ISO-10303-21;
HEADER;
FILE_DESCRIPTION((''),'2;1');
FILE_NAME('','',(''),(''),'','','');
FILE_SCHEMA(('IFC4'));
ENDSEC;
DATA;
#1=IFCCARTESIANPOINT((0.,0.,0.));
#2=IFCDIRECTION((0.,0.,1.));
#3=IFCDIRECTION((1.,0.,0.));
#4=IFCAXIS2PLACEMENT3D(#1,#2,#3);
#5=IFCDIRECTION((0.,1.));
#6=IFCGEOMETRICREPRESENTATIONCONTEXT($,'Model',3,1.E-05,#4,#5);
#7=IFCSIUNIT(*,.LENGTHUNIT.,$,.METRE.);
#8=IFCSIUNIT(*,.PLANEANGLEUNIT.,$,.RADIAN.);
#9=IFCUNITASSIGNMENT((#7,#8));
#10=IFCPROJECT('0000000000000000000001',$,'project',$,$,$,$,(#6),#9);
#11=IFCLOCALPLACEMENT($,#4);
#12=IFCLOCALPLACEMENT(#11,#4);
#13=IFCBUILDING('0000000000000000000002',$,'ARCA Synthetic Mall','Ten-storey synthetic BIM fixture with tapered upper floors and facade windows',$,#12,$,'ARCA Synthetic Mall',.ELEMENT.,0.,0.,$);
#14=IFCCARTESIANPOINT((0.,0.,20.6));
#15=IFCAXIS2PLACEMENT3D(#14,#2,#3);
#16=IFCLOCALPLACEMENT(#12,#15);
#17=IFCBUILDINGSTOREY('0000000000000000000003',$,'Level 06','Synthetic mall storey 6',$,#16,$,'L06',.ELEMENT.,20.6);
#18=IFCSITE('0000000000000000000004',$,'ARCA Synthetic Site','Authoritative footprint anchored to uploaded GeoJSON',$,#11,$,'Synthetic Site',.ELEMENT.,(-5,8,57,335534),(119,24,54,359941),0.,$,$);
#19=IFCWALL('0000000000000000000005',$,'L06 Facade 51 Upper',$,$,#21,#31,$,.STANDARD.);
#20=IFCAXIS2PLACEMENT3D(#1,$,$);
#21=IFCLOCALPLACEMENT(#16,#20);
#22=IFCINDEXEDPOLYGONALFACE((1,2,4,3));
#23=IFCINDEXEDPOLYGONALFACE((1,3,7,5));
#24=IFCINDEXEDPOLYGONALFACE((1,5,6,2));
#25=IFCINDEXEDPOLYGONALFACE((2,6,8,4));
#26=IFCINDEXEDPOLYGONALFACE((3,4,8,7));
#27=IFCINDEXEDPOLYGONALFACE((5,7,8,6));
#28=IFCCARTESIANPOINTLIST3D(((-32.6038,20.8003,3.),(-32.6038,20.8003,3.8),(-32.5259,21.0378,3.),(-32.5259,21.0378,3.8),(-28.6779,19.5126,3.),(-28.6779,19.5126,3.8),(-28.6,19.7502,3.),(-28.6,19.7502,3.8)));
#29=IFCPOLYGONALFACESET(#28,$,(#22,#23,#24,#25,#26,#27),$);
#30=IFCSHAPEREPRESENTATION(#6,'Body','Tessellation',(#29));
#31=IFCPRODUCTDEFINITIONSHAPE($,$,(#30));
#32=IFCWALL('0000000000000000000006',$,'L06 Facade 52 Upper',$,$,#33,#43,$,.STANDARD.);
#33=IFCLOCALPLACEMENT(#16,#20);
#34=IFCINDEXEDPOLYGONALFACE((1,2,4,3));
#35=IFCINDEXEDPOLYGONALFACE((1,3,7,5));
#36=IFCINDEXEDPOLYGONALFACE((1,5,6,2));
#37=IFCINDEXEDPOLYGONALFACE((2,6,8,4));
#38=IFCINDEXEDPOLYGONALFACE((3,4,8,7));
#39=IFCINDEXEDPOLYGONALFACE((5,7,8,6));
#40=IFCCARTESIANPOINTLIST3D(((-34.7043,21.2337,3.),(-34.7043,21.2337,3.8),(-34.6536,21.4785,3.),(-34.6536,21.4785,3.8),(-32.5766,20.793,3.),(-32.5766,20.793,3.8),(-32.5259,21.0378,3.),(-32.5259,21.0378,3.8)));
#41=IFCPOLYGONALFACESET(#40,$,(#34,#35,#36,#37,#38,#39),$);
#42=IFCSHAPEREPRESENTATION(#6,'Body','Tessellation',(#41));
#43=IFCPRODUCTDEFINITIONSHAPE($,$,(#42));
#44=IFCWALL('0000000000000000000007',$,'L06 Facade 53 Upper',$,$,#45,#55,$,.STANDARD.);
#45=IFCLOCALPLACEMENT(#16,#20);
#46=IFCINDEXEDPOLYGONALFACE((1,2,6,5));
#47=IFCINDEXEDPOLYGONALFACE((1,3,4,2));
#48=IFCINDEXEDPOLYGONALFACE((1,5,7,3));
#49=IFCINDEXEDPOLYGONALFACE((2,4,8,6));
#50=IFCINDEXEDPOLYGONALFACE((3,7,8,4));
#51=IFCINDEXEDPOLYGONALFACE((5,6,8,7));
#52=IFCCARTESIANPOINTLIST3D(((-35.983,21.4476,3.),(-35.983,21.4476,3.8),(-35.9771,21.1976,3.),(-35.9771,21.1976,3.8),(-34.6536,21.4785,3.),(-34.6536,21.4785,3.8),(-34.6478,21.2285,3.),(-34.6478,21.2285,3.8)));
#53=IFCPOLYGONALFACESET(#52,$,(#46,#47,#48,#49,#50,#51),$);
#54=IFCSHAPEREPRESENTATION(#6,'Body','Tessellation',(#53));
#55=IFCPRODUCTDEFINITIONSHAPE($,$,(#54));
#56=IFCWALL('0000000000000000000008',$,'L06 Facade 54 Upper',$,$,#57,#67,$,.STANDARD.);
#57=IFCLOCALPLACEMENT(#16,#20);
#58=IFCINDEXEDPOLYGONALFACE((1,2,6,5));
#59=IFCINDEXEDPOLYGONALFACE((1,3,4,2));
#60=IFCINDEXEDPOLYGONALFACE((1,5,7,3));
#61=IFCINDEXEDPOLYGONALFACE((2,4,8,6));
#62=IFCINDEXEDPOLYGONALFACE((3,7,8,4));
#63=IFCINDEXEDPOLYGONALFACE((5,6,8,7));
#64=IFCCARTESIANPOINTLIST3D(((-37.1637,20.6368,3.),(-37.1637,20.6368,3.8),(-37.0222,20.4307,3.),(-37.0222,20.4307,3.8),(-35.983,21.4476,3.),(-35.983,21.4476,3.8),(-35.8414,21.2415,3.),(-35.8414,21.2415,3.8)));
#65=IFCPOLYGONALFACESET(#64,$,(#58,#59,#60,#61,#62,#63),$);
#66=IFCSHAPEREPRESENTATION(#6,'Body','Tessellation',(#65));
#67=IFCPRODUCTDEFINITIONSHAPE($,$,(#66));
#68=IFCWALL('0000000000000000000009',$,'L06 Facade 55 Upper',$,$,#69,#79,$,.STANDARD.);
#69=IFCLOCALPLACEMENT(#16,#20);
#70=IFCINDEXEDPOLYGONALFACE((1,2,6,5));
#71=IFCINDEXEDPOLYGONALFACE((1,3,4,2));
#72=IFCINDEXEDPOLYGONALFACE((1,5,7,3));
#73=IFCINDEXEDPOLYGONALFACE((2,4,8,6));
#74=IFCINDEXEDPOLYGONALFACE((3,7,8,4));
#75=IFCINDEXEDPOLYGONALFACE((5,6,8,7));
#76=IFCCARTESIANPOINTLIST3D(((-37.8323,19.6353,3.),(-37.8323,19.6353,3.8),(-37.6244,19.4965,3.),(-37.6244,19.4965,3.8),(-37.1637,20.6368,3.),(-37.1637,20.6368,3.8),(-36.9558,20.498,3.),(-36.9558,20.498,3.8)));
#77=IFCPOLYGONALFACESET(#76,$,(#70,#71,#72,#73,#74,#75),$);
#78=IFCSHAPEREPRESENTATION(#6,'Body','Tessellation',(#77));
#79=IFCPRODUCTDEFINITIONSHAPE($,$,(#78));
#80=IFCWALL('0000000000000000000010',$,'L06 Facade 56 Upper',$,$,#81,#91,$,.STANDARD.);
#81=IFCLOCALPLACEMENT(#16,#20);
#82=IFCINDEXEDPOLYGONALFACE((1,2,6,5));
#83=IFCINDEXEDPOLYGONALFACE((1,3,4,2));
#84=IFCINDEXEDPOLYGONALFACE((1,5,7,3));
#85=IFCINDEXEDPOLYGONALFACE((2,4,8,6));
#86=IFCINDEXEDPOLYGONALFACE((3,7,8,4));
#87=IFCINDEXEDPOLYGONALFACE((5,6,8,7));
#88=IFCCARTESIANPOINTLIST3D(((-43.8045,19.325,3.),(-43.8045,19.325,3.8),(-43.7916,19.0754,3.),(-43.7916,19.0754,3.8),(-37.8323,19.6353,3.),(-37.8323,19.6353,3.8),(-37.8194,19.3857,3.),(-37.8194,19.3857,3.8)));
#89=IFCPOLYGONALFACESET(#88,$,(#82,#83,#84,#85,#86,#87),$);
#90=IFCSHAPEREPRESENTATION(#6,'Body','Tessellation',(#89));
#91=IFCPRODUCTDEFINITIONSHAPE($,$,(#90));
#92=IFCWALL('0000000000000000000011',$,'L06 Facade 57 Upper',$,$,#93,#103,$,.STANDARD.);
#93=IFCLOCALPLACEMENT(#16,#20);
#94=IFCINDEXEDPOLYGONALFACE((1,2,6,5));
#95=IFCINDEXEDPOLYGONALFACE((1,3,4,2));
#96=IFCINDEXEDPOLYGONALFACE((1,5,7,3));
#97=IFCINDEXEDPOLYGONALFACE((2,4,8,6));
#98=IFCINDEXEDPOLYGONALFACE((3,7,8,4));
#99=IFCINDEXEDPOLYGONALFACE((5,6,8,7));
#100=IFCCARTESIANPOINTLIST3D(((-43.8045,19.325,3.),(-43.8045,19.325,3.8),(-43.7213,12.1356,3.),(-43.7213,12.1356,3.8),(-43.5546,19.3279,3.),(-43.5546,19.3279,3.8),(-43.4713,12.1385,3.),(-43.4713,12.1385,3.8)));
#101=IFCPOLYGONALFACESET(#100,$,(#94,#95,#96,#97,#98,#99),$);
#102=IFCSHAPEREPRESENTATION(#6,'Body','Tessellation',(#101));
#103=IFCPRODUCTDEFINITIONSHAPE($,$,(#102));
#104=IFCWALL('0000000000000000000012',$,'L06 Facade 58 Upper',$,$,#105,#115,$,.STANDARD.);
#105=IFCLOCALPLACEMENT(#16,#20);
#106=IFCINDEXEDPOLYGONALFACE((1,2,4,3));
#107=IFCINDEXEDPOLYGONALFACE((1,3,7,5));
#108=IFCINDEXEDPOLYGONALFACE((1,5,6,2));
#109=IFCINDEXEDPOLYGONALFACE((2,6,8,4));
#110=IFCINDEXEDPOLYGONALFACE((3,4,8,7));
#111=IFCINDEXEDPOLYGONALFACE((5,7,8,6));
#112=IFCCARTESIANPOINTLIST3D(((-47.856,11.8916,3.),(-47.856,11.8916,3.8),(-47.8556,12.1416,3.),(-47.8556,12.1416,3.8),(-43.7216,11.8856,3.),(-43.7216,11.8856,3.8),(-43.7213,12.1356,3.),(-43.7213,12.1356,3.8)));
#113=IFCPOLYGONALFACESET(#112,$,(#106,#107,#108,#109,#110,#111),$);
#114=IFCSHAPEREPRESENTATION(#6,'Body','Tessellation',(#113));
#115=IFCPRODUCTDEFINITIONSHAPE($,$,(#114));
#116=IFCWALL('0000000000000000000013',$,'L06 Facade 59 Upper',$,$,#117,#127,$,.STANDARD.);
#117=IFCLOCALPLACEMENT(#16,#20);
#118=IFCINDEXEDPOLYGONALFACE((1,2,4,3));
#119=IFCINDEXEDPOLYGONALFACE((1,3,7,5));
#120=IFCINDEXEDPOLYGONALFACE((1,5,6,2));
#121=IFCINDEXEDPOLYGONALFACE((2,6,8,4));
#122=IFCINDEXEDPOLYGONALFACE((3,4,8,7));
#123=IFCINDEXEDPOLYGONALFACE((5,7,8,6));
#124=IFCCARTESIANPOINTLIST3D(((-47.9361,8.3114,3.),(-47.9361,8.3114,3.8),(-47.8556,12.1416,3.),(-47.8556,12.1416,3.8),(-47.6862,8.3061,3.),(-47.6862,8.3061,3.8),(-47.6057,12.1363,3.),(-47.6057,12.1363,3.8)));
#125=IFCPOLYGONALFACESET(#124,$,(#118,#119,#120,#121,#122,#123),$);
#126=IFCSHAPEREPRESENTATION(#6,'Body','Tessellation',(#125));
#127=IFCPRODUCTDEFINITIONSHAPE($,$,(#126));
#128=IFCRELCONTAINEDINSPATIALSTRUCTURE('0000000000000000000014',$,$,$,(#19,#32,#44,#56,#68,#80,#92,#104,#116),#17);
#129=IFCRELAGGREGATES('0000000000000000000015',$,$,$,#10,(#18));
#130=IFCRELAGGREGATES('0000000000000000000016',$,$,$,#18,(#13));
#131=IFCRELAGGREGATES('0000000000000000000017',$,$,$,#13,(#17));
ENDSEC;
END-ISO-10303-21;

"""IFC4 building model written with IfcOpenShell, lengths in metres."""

from ifc_helpers import new_model, si_unit, direction, frame, origin_with_axes, place, context, project, spatial, polyline, outline, extrude, element, save


model = new_model("IFC4")

# Units and contexts
model_context = context("Model", 3, precision=1e-05, world=origin_with_axes(), true_north=direction((0.0, 1.0)))
ifc_project = project(units=[si_unit("LENGTHUNIT", "METRE"), si_unit("PLANEANGLEUNIT", "RADIAN")], contexts=[model_context])

# Site, building, storey
site_placement = place(None, origin_with_axes())
site = spatial("IfcSite", under=ifc_project, at=site_placement, Name="ARCA Synthetic Site", Description="Authoritative footprint anchored to uploaded GeoJSON", LongName="Synthetic Site", CompositionType="ELEMENT", RefLatitude=(-5, 8, 57, 335534), RefLongitude=(119, 24, 54, 359941), RefElevation=0.0)
building_placement = place(site_placement, origin_with_axes())
building = spatial("IfcBuilding", under=site, at=building_placement, Name="ARCA Synthetic Mall", Description="Ten-storey synthetic BIM fixture with tapered upper floors and facade windows", LongName="ARCA Synthetic Mall", CompositionType="ELEMENT", ElevationOfRefHeight=0.0, ElevationOfTerrain=0.0)
storey_placement = place(building_placement, frame((0.0, 0.0, 20.6), z_axis=(0.0, 0.0, 1.0), x_axis=(1.0, 0.0, 0.0)))
storey = spatial("IfcBuildingStorey", under=building, at=storey_placement, Name="Level 06", Description="Synthetic mall storey 6", LongName="L06", CompositionType="ELEMENT", Elevation=20.6)

# Walls
wall_1_placement = place(storey_placement, frame((0.0, 0.0, 3.0), z_axis=(0.0, 0.0, 1.0), x_axis=(1.0, 0.0, 0.0)))
element("IfcWall", 1, at=wall_1_placement, inside=storey, Name="L06 Facade 51 Upper", PredefinedType="STANDARD", context=model_context, shape_type="SweptSolid", body=[
    extrude(outline(polyline([(-28.6, 19.7502), (-32.5259, 21.0378), (-32.6038, 20.8003), (-28.6779, 19.5126), (-28.6, 19.7502)])), origin_with_axes(), (0.0, 0.0, 1.0), 0.8),
])
wall_2_placement = place(storey_placement, frame((0.0, 0.0, 3.0), z_axis=(0.0, 0.0, 1.0), x_axis=(1.0, 0.0, 0.0)))
element("IfcWall", 2, at=wall_2_placement, inside=storey, Name="L06 Facade 52 Upper", PredefinedType="STANDARD", context=model_context, shape_type="SweptSolid", body=[
    extrude(outline(polyline([(-32.5259, 21.0378), (-34.6536, 21.4785), (-34.7043, 21.2337), (-32.5766, 20.793), (-32.5259, 21.0378)])), origin_with_axes(), (0.0, 0.0, 1.0), 0.8),
])
wall_3_placement = place(storey_placement, frame((0.0, 0.0, 3.0), z_axis=(0.0, 0.0, 1.0), x_axis=(1.0, 0.0, 0.0)))
element("IfcWall", 3, at=wall_3_placement, inside=storey, Name="L06 Facade 53 Upper", PredefinedType="STANDARD", context=model_context, shape_type="SweptSolid", body=[
    extrude(outline(polyline([(-34.6536, 21.4785), (-35.983, 21.4475), (-35.9771, 21.1976), (-34.6478, 21.2285), (-34.6536, 21.4785)])), origin_with_axes(), (0.0, 0.0, 1.0), 0.8),
])
wall_4_placement = place(storey_placement, frame((0.0, 0.0, 3.0), z_axis=(0.0, 0.0, 1.0), x_axis=(1.0, 0.0, 0.0)))
element("IfcWall", 4, at=wall_4_placement, inside=storey, Name="L06 Facade 54 Upper", PredefinedType="STANDARD", context=model_context, shape_type="SweptSolid", body=[
    extrude(outline(polyline([(-35.983, 21.4475), (-37.1637, 20.6368), (-37.0222, 20.4307), (-35.8414, 21.2415), (-35.983, 21.4475)])), origin_with_axes(), (0.0, 0.0, 1.0), 0.8),
])
wall_5_placement = place(storey_placement, frame((0.0, 0.0, 3.0), z_axis=(0.0, 0.0, 1.0), x_axis=(1.0, 0.0, 0.0)))
element("IfcWall", 5, at=wall_5_placement, inside=storey, Name="L06 Facade 55 Upper", PredefinedType="STANDARD", context=model_context, shape_type="SweptSolid", body=[
    extrude(outline(polyline([(-37.1637, 20.6368), (-37.8323, 19.6353), (-37.6244, 19.4965), (-36.9558, 20.498), (-37.1637, 20.6368)])), origin_with_axes(), (0.0, 0.0, 1.0), 0.8),
])
wall_6_placement = place(storey_placement, frame((0.0, 0.0, 3.0), z_axis=(0.0, 0.0, 1.0), x_axis=(1.0, 0.0, 0.0)))
element("IfcWall", 6, at=wall_6_placement, inside=storey, Name="L06 Facade 56 Upper", PredefinedType="STANDARD", context=model_context, shape_type="SweptSolid", body=[
    extrude(outline(polyline([(-37.8323, 19.6353), (-43.8045, 19.325), (-43.7916, 19.0754), (-37.8194, 19.3857), (-37.8323, 19.6353)])), origin_with_axes(), (0.0, 0.0, 1.0), 0.8),
])
wall_7_placement = place(storey_placement, frame((0.0, 0.0, 3.0), z_axis=(0.0, 0.0, 1.0), x_axis=(1.0, 0.0, 0.0)))
element("IfcWall", 7, at=wall_7_placement, inside=storey, Name="L06 Facade 57 Upper", PredefinedType="STANDARD", context=model_context, shape_type="SweptSolid", body=[
    extrude(outline(polyline([(-43.8045, 19.325), (-43.7213, 12.1356), (-43.4713, 12.1385), (-43.5546, 19.3279), (-43.8045, 19.325)])), origin_with_axes(), (0.0, 0.0, 1.0), 0.8),
])
wall_8_placement = place(storey_placement, frame((0.0, 0.0, 3.0), z_axis=(0.0, 0.0, 1.0), x_axis=(1.0, 0.0, 0.0)))
element("IfcWall", 8, at=wall_8_placement, inside=storey, Name="L06 Facade 58 Upper", PredefinedType="STANDARD", context=model_context, shape_type="SweptSolid", body=[
    extrude(outline(polyline([(-43.7213, 12.1356), (-47.8556, 12.1416), (-47.856, 11.8916), (-43.7216, 11.8856), (-43.7213, 12.1356)])), origin_with_axes(), (0.0, 0.0, 1.0), 0.8),
])
wall_9_placement = place(storey_placement, frame((0.0, 0.0, 3.0), z_axis=(0.0, 0.0, 1.0), x_axis=(1.0, 0.0, 0.0)))
element("IfcWall", 9, at=wall_9_placement, inside=storey, Name="L06 Facade 59 Upper", PredefinedType="STANDARD", context=model_context, shape_type="SweptSolid", body=[
    extrude(outline(polyline([(-47.8556, 12.1416), (-47.9361, 8.3114), (-47.6862, 8.3061), (-47.6057, 12.1363), (-47.8556, 12.1416)])), origin_with_axes(), (0.0, 0.0, 1.0), 0.8),
])

save(model, "model.ifc")
